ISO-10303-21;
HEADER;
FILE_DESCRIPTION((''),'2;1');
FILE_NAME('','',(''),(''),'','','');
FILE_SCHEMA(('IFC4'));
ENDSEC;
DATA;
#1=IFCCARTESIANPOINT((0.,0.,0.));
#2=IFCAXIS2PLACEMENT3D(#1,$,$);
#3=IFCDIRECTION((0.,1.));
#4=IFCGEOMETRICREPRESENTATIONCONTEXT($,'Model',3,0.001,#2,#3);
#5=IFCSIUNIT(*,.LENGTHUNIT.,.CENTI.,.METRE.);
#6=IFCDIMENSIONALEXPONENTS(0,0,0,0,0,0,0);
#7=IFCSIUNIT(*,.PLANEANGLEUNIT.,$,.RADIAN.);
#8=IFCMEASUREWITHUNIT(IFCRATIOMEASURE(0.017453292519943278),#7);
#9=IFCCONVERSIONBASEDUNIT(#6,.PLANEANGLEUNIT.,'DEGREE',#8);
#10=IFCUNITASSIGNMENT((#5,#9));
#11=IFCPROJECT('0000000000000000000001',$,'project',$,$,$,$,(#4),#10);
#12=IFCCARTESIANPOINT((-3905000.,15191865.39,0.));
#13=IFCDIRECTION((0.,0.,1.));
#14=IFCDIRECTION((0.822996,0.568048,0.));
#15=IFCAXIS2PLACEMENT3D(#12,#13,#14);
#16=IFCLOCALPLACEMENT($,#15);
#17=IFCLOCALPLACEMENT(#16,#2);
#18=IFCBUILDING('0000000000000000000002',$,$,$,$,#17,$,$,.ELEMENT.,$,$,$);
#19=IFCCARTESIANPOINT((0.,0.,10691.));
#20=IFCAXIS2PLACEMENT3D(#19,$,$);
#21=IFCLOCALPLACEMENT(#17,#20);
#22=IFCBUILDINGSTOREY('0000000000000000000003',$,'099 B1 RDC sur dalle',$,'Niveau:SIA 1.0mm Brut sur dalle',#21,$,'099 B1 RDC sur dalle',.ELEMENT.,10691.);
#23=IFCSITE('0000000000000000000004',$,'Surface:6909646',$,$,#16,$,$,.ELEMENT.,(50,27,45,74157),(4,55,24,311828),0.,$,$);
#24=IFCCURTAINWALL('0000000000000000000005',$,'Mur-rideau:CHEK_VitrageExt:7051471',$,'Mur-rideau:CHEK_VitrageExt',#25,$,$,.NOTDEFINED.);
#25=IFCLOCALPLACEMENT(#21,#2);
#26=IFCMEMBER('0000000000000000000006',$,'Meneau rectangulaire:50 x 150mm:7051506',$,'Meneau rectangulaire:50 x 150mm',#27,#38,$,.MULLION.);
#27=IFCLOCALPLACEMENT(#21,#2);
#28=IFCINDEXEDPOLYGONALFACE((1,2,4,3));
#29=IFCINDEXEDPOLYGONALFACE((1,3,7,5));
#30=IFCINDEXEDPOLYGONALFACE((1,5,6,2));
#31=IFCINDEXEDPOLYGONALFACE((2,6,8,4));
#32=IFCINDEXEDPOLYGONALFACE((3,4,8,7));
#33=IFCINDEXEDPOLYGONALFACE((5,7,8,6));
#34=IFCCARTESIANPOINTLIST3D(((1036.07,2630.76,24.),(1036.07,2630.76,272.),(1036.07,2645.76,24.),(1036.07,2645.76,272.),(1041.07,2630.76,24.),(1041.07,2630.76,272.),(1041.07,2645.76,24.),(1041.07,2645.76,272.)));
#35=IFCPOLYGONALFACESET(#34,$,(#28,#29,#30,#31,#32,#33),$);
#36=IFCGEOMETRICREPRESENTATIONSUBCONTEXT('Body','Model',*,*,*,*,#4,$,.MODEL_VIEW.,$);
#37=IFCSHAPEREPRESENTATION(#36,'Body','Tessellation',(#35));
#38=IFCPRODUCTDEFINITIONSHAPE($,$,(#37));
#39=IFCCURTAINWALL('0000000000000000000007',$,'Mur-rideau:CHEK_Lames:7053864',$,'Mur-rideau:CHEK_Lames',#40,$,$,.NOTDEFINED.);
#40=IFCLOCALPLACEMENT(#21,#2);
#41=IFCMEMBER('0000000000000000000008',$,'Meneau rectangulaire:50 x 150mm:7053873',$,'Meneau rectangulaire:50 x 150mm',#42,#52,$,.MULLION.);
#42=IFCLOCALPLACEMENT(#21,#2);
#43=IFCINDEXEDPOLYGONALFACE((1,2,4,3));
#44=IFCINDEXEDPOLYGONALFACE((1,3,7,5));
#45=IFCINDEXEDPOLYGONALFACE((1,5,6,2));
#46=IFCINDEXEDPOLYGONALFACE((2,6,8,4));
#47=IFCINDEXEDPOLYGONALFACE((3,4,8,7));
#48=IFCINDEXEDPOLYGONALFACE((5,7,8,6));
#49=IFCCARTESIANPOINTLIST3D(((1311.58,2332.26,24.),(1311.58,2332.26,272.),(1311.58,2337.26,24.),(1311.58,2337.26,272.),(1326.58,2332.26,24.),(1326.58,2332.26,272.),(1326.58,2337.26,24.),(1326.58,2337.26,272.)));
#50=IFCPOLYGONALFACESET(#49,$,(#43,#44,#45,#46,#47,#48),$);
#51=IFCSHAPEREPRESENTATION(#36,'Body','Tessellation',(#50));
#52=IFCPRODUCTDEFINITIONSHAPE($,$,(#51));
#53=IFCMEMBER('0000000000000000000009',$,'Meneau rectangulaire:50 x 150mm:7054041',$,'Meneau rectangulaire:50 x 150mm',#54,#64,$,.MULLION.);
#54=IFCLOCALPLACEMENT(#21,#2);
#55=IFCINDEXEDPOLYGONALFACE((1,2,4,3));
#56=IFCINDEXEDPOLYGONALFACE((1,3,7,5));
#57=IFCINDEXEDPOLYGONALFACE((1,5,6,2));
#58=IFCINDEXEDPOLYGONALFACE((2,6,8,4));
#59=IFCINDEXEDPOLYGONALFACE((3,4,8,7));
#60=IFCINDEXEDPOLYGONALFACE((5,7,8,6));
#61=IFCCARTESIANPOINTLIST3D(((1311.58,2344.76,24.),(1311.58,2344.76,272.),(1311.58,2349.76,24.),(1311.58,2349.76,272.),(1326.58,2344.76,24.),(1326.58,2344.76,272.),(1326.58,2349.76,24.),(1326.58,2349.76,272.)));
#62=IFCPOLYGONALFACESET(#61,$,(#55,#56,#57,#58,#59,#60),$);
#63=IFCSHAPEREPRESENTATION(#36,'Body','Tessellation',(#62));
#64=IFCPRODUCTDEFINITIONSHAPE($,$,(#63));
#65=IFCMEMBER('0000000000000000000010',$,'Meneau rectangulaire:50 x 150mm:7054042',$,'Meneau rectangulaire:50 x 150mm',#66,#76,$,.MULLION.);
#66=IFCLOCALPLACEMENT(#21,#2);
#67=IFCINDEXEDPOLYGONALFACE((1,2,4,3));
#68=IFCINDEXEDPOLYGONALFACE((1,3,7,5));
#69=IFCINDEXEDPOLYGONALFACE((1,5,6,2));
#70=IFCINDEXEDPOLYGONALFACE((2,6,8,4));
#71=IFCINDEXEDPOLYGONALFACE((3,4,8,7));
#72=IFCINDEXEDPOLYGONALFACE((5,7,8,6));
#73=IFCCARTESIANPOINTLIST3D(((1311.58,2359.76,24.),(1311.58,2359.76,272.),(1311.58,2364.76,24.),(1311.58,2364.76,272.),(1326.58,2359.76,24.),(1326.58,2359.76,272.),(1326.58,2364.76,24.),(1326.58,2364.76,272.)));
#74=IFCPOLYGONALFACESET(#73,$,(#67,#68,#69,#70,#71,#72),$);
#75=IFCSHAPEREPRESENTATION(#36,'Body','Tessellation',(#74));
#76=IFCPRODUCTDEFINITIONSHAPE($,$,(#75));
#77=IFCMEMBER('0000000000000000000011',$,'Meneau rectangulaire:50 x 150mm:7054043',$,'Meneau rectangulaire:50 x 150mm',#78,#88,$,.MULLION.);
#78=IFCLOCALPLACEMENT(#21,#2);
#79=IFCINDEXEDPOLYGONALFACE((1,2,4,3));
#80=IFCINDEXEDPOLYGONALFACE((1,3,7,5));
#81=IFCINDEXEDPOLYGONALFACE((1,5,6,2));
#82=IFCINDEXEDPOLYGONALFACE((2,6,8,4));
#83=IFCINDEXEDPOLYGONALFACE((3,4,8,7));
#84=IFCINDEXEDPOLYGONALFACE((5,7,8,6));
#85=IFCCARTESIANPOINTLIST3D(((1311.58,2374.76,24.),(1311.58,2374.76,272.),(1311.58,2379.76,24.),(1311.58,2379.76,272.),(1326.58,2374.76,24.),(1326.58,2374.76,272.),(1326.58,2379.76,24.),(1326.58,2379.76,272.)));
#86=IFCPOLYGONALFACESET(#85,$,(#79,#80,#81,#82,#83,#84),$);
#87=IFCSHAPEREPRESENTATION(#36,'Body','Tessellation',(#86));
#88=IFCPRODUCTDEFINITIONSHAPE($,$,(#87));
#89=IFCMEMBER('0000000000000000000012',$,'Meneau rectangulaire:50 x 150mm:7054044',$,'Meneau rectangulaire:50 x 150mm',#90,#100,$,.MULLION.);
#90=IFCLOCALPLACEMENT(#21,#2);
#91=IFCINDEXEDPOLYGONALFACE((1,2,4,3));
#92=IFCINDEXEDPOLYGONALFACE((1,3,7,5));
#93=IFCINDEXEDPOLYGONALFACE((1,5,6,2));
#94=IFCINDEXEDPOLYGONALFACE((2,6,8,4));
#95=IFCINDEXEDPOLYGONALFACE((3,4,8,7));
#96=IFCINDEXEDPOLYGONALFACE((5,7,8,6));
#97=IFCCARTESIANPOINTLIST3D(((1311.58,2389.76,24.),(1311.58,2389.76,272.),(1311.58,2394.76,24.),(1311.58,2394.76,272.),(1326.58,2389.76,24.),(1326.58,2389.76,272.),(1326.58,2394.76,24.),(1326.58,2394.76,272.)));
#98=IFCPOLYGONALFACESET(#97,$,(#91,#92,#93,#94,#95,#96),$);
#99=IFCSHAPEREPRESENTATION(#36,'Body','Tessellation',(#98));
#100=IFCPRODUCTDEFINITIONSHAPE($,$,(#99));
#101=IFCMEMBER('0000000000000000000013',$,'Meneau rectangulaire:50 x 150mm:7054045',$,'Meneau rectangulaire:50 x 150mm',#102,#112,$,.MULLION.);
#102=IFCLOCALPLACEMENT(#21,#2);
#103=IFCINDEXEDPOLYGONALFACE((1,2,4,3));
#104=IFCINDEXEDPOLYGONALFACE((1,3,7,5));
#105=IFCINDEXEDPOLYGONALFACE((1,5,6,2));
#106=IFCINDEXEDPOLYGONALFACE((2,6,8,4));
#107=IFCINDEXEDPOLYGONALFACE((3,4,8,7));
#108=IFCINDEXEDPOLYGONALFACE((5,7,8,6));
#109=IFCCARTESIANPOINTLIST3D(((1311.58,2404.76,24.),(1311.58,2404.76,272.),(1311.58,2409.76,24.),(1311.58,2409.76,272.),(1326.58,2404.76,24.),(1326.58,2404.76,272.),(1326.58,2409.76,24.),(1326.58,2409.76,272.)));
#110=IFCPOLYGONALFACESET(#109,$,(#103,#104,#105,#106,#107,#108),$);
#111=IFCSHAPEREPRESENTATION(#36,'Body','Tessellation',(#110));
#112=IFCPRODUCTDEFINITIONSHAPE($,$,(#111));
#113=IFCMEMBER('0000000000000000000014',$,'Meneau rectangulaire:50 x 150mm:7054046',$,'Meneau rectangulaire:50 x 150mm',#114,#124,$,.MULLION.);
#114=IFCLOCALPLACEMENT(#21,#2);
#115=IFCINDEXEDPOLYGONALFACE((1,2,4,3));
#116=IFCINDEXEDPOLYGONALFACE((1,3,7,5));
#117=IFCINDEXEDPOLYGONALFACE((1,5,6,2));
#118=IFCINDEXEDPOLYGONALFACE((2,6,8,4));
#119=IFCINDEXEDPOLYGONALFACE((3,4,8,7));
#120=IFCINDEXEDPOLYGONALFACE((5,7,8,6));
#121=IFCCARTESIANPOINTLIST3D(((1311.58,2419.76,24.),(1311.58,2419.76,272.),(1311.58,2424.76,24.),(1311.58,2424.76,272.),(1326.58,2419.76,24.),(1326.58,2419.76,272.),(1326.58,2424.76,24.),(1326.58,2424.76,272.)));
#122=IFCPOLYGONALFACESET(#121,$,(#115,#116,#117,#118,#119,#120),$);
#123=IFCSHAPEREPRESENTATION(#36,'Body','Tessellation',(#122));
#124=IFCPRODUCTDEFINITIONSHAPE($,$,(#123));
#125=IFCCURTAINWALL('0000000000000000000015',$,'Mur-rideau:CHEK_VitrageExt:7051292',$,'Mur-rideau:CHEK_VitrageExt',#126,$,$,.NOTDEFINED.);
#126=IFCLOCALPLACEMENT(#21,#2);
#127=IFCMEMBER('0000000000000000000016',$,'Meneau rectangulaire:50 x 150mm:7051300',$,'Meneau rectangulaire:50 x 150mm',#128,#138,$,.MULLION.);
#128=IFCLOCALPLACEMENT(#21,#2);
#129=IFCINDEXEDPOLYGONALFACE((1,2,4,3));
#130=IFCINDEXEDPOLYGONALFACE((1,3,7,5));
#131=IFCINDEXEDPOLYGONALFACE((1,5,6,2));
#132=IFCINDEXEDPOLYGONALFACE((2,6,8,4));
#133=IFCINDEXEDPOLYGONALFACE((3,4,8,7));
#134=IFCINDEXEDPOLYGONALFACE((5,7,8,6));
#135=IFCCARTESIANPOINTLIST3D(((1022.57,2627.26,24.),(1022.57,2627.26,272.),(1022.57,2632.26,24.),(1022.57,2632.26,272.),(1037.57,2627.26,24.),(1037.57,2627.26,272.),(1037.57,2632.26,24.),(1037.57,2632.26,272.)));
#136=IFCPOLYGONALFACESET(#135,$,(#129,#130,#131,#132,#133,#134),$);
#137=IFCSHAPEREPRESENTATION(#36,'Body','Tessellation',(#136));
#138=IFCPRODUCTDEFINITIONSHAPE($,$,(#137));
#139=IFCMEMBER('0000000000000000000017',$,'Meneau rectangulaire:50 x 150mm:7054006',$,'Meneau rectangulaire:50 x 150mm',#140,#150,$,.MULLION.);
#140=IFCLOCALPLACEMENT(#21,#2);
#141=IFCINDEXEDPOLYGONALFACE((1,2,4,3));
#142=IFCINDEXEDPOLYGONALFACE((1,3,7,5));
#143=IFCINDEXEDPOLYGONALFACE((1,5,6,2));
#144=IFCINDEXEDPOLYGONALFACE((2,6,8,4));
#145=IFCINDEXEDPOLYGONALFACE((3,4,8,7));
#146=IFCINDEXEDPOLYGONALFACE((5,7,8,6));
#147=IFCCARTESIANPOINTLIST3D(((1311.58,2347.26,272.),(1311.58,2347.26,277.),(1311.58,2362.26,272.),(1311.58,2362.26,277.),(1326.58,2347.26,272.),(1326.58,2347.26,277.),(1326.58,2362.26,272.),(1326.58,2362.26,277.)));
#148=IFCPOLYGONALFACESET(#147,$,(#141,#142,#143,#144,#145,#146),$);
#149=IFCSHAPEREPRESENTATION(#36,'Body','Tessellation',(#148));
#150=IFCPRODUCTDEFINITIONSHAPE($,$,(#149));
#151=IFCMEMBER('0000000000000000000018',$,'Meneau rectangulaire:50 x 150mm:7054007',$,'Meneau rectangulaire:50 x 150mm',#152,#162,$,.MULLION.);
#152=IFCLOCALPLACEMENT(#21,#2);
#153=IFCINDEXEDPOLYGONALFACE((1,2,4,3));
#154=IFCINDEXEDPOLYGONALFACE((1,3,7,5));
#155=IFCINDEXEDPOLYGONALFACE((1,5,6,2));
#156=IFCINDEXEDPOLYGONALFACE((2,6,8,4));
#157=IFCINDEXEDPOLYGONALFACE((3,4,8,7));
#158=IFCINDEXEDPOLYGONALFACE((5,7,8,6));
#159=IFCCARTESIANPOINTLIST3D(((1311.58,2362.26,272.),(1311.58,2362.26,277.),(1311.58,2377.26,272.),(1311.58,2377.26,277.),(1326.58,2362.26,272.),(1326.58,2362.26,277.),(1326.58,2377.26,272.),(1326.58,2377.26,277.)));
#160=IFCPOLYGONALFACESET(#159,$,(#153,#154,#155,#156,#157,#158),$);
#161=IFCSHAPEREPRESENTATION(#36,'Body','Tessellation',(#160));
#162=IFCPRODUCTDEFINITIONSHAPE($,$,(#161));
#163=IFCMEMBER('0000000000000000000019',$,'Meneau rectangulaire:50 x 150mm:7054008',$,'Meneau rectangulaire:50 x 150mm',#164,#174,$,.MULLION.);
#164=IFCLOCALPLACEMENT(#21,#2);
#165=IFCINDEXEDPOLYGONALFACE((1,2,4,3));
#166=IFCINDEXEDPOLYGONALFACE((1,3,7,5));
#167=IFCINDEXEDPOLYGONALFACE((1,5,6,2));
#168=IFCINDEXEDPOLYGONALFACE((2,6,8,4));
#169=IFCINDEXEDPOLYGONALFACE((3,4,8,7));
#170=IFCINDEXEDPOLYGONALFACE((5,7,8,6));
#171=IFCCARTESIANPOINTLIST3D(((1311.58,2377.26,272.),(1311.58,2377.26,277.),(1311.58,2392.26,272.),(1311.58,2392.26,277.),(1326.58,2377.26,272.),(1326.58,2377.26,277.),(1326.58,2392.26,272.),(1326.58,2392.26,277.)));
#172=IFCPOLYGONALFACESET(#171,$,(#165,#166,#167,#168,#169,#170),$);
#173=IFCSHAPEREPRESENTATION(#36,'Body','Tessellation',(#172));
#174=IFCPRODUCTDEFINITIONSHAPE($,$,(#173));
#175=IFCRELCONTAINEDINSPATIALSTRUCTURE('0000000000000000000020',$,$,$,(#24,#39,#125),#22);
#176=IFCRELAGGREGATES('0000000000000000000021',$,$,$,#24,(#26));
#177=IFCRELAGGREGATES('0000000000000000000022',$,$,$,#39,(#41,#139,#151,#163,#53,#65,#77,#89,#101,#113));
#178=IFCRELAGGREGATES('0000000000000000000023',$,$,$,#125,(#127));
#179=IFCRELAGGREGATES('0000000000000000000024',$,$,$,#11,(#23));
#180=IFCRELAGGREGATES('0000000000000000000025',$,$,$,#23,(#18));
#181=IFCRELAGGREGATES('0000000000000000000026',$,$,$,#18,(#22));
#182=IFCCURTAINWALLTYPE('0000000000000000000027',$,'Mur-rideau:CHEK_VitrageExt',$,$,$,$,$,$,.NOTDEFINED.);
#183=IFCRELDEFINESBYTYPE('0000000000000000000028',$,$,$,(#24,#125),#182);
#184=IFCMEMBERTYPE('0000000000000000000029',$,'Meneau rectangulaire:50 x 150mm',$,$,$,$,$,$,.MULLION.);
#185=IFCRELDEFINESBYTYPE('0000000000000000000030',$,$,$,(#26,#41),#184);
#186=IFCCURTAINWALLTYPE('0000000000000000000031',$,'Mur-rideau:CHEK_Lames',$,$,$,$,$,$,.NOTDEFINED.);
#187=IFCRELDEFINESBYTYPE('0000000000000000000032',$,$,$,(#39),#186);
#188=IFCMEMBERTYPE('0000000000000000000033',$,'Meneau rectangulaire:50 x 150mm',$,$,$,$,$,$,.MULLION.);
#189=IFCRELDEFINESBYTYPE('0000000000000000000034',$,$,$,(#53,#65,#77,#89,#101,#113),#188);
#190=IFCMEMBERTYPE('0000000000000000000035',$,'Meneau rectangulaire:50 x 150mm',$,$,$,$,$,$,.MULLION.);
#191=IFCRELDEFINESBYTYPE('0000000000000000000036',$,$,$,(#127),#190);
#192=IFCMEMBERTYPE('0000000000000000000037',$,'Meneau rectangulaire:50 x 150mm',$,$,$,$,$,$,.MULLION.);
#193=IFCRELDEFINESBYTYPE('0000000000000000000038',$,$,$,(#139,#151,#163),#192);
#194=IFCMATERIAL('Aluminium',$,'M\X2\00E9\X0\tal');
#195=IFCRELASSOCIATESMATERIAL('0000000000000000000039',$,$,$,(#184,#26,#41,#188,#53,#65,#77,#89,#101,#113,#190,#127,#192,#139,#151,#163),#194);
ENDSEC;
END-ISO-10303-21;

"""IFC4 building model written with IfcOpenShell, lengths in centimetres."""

from ifc_helpers import new_model, entity, si_unit, converted_unit, direction, frame, origin, place, context, subcontext, project, spatial, indexed_curve, outline, extrude, source, transform, mapped, material, type_object, type_shapes, element, aggregate, save


model = new_model("IFC4")

# Units and contexts
model_context = context("Model", 3, precision=0.001, world=origin(), true_north=direction((0.0, 1.0)))
body_context = subcontext(model_context, "Body", "Model", "MODEL_VIEW")
ifc_project = project(units=[si_unit("LENGTHUNIT", "METRE", prefix="CENTI"), converted_unit("PLANEANGLEUNIT", "DEGREE", entity("IfcRatioMeasure", 0.017453292519943278), si_unit("PLANEANGLEUNIT", "RADIAN"), dimensions=[0, 0, 0, 0, 0, 0, 0])], contexts=[model_context])

# Site, building, storey
site_placement = place(None, frame((-3905000.0, 15191865.39, 0.0), z_axis=(0.0, 0.0, 1.0), x_axis=(0.822996, 0.568048, 0.0)))
site = spatial("IfcSite", under=ifc_project, at=site_placement, Name="Surface:6909646", CompositionType="ELEMENT", RefLatitude=(50, 27, 45, 74157), RefLongitude=(4, 55, 24, 311828), RefElevation=0.0)
building_placement = place(site_placement, origin())
building = spatial("IfcBuilding", under=site, at=building_placement, CompositionType="ELEMENT")
storey_placement = place(building_placement, frame((0.0, 0.0, 10691.0)))
storey = spatial("IfcBuildingStorey", under=building, at=storey_placement, Name="099 B1 RDC sur dalle", ObjectType="Niveau:SIA 1.0mm Brut sur dalle", LongName="099 B1 RDC sur dalle", CompositionType="ELEMENT", Elevation=10691.0)

# Curtain wall, member
curtain_wall_type_1 = type_object("IfcCurtainWallType", Name="Mur-rideau:CHEK_VitrageExt", PredefinedType="NOTDEFINED")
curtain_wall_1_placement = place(storey_placement, frame((0.0, 0.0, -10691.0)))
curtain_wall_1 = element("IfcCurtainWall", 1, at=curtain_wall_1_placement, inside=storey, type_object=curtain_wall_type_1, Name="Mur-rideau:CHEK_VitrageExt:7051471", ObjectType="Mur-rideau:CHEK_VitrageExt", PredefinedType="NOTDEFINED")
ifc_material_1 = material(Name="Aluminium", Category="Métal")
member_type_1 = type_object("IfcMemberType", Name="Meneau rectangulaire:50 x 150mm", PredefinedType="MULLION", material=ifc_material_1)
shared_shape_1 = source(origin(), body_context, "Body", "SweptSolid", [
    extrude(outline(indexed_curve([(-7.5, -2.5), (7.5, -2.5), (7.5, 2.5), (-7.5, 2.5), (-7.5, -2.5)], self_intersect=False)), frame((-2.5, -6.0, -248.0), z_axis=(0.0, 0.0, 1.0), x_axis=(0.0, -1.0, 0.0)), (0.0, 0.0, 1.0), 248.0),
])
type_shapes(member_type_1, [shared_shape_1])
member_1_placement = place(curtain_wall_1_placement, frame((1036.07, 2632.26, 10963.0), z_axis=(0.0, 0.0, 1.0), x_axis=(-1.0, 0.0, 0.0)))
member_1 = element("IfcMember", 2, at=member_1_placement, type_object=member_type_1, material=ifc_material_1, Name="Meneau rectangulaire:50 x 150mm:7051506", ObjectType="Meneau rectangulaire:50 x 150mm", PredefinedType="MULLION", context=body_context, shape_type="MappedRepresentation", body=[
    mapped(shared_shape_1, transform((0.0, 0.0, 0.0), scale=1.0)),
])
aggregate(curtain_wall_1, [member_1])

# Curtain wall, members
curtain_wall_type_2 = type_object("IfcCurtainWallType", Name="Mur-rideau:CHEK_Lames", PredefinedType="NOTDEFINED")
curtain_wall_2_placement = place(storey_placement, frame((0.0, 0.0, -10691.0)))
curtain_wall_2 = element("IfcCurtainWall", 3, at=curtain_wall_2_placement, inside=storey, type_object=curtain_wall_type_2, Name="Mur-rideau:CHEK_Lames:7053864", ObjectType="Mur-rideau:CHEK_Lames", PredefinedType="NOTDEFINED")
member_2_placement = place(curtain_wall_2_placement, frame((1325.08, 2332.26, 10963.0), z_axis=(0.0, 0.0, 1.0), x_axis=(0.0, -1.0, 0.0)))
member_2 = element("IfcMember", 4, at=member_2_placement, type_object=member_type_1, material=ifc_material_1, Name="Meneau rectangulaire:50 x 150mm:7053873", ObjectType="Meneau rectangulaire:50 x 150mm", PredefinedType="MULLION", context=body_context, shape_type="MappedRepresentation", body=[
    mapped(shared_shape_1, transform((0.0, 0.0, 0.0), scale=1.0)),
])
member_type_2 = type_object("IfcMemberType", Name="Meneau rectangulaire:50 x 150mm", PredefinedType="MULLION", material=ifc_material_1)
shared_shape_2 = source(origin(), body_context, "Body", "SweptSolid", [
    extrude(outline(indexed_curve([(-7.5, -2.5), (7.5, -2.5), (7.5, 2.5), (-7.5, 2.5), (-7.5, -2.5)], self_intersect=False)), frame((0.0, -6.0, -248.0), z_axis=(0.0, 0.0, 1.0), x_axis=(0.0, -1.0, 0.0)), (0.0, 0.0, 1.0), 248.0),
])
type_shapes(member_type_2, [shared_shape_2])
member_3_placement = place(curtain_wall_2_placement, frame((1325.08, 2347.26, 10715.0), z_axis=(0.0, 0.0, -1.0), x_axis=(0.0, 1.0, 0.0)))
member_3 = element("IfcMember", 5, at=member_3_placement, type_object=member_type_2, material=ifc_material_1, Name="Meneau rectangulaire:50 x 150mm:7054041", ObjectType="Meneau rectangulaire:50 x 150mm", PredefinedType="MULLION", context=body_context, shape_type="MappedRepresentation", body=[
    mapped(shared_shape_2, transform((0.0, 0.0, 0.0), scale=1.0)),
])
member_4_placement = place(curtain_wall_2_placement, frame((1325.08, 2362.26, 10715.0), z_axis=(0.0, 0.0, -1.0), x_axis=(0.0, 1.0, 0.0)))
member_4 = element("IfcMember", 6, at=member_4_placement, type_object=member_type_2, material=ifc_material_1, Name="Meneau rectangulaire:50 x 150mm:7054042", ObjectType="Meneau rectangulaire:50 x 150mm", PredefinedType="MULLION", context=body_context, shape_type="MappedRepresentation", body=[
    mapped(shared_shape_2, transform((0.0, 0.0, 0.0), scale=1.0)),
])
member_5_placement = place(curtain_wall_2_placement, frame((1325.08, 2377.26, 10715.0), z_axis=(0.0, 0.0, -1.0), x_axis=(0.0, 1.0, 0.0)))
member_5 = element("IfcMember", 7, at=member_5_placement, type_object=member_type_2, material=ifc_material_1, Name="Meneau rectangulaire:50 x 150mm:7054043", ObjectType="Meneau rectangulaire:50 x 150mm", PredefinedType="MULLION", context=body_context, shape_type="MappedRepresentation", body=[
    mapped(shared_shape_2, transform((0.0, 0.0, 0.0), scale=1.0)),
])
member_6_placement = place(curtain_wall_2_placement, frame((1325.08, 2392.26, 10715.0), z_axis=(0.0, 0.0, -1.0), x_axis=(0.0, 1.0, 0.0)))
member_6 = element("IfcMember", 8, at=member_6_placement, type_object=member_type_2, material=ifc_material_1, Name="Meneau rectangulaire:50 x 150mm:7054044", ObjectType="Meneau rectangulaire:50 x 150mm", PredefinedType="MULLION", context=body_context, shape_type="MappedRepresentation", body=[
    mapped(shared_shape_2, transform((0.0, 0.0, 0.0), scale=1.0)),
])
member_7_placement = place(curtain_wall_2_placement, frame((1325.08, 2407.26, 10715.0), z_axis=(0.0, 0.0, -1.0), x_axis=(0.0, 1.0, 0.0)))
member_7 = element("IfcMember", 9, at=member_7_placement, type_object=member_type_2, material=ifc_material_1, Name="Meneau rectangulaire:50 x 150mm:7054045", ObjectType="Meneau rectangulaire:50 x 150mm", PredefinedType="MULLION", context=body_context, shape_type="MappedRepresentation", body=[
    mapped(shared_shape_2, transform((0.0, 0.0, 0.0), scale=1.0)),
])
member_8_placement = place(curtain_wall_2_placement, frame((1325.08, 2422.26, 10715.0), z_axis=(0.0, 0.0, -1.0), x_axis=(0.0, 1.0, 0.0)))
member_8 = element("IfcMember", 10, at=member_8_placement, type_object=member_type_2, material=ifc_material_1, Name="Meneau rectangulaire:50 x 150mm:7054046", ObjectType="Meneau rectangulaire:50 x 150mm", PredefinedType="MULLION", context=body_context, shape_type="MappedRepresentation", body=[
    mapped(shared_shape_2, transform((0.0, 0.0, 0.0), scale=1.0)),
])

# Curtain wall, member
curtain_wall_3_placement = place(storey_placement, frame((0.0, 0.0, -10691.0)))
curtain_wall_3 = element("IfcCurtainWall", 11, at=curtain_wall_3_placement, inside=storey, type_object=curtain_wall_type_1, Name="Mur-rideau:CHEK_VitrageExt:7051292", ObjectType="Mur-rideau:CHEK_VitrageExt", PredefinedType="NOTDEFINED")
member_type_3 = type_object("IfcMemberType", Name="Meneau rectangulaire:50 x 150mm", PredefinedType="MULLION", material=ifc_material_1)
shared_shape_3 = source(origin(), body_context, "Body", "SweptSolid", [
    extrude(outline(indexed_curve([(-7.5, -2.5), (7.5, -2.5), (7.5, 2.5), (-7.5, 2.5), (-7.5, -2.5)], self_intersect=False)), frame((-2.5, -6.0, -248.0), z_axis=(0.0, 0.0, 1.0), x_axis=(0.0, -1.0, 0.0)), (0.0, 0.0, 1.0), 248.0),
])
type_shapes(member_type_3, [shared_shape_3])
member_9_placement = place(curtain_wall_3_placement, frame((1036.07, 2632.26, 10715.0), z_axis=(0.0, 0.0, -1.0), x_axis=(0.0, 1.0, 0.0)))
member_9 = element("IfcMember", 12, at=member_9_placement, type_object=member_type_3, material=ifc_material_1, Name="Meneau rectangulaire:50 x 150mm:7051300", ObjectType="Meneau rectangulaire:50 x 150mm", PredefinedType="MULLION", context=body_context, shape_type="MappedRepresentation", body=[
    mapped(shared_shape_3, transform((0.0, 0.0, 0.0), scale=1.0)),
])

# Members
member_type_4 = type_object("IfcMemberType", Name="Meneau rectangulaire:50 x 150mm", PredefinedType="MULLION", material=ifc_material_1)
shared_shape_4 = source(origin(), body_context, "Body", "SweptSolid", [
    extrude(outline(indexed_curve([(-7.5, -2.5), (7.5, -2.5), (7.5, 2.5), (-7.5, 2.5), (-7.5, -2.5)], self_intersect=False)), frame((-2.5, -6.0, -15.0), z_axis=(0.0, 0.0, 1.0), x_axis=(0.0, -1.0, 0.0)), (0.0, 0.0, 1.0), 15.0),
])
type_shapes(member_type_4, [shared_shape_4])
member_10_placement = place(curtain_wall_2_placement, frame((1325.08, 2362.26, 10968.0), z_axis=(0.0, 1.0, 0.0), x_axis=(0.0, 0.0, 1.0)))
member_10 = element("IfcMember", 13, at=member_10_placement, type_object=member_type_4, material=ifc_material_1, Name="Meneau rectangulaire:50 x 150mm:7054006", ObjectType="Meneau rectangulaire:50 x 150mm", PredefinedType="MULLION", context=body_context, shape_type="MappedRepresentation", body=[
    mapped(shared_shape_4, transform((0.0, 0.0, 0.0), scale=1.0)),
])
member_11_placement = place(curtain_wall_2_placement, frame((1325.08, 2377.26, 10968.0), z_axis=(0.0, 1.0, 0.0), x_axis=(0.0, 0.0, 1.0)))
member_11 = element("IfcMember", 14, at=member_11_placement, type_object=member_type_4, material=ifc_material_1, Name="Meneau rectangulaire:50 x 150mm:7054007", ObjectType="Meneau rectangulaire:50 x 150mm", PredefinedType="MULLION", context=body_context, shape_type="MappedRepresentation", body=[
    mapped(shared_shape_4, transform((0.0, 0.0, 0.0), scale=1.0)),
])
member_12_placement = place(curtain_wall_2_placement, frame((1325.08, 2392.26, 10968.0), z_axis=(0.0, 1.0, 0.0), x_axis=(0.0, 0.0, 1.0)))
member_12 = element("IfcMember", 15, at=member_12_placement, type_object=member_type_4, material=ifc_material_1, Name="Meneau rectangulaire:50 x 150mm:7054008", ObjectType="Meneau rectangulaire:50 x 150mm", PredefinedType="MULLION", context=body_context, shape_type="MappedRepresentation", body=[
    mapped(shared_shape_4, transform((0.0, 0.0, 0.0), scale=1.0)),
])
aggregate(curtain_wall_2, [member_2, member_10, member_11, member_12, member_3, member_4, member_5, member_6, member_7, member_8])

aggregate(curtain_wall_3, [member_9])

save(model, "model.ifc")
